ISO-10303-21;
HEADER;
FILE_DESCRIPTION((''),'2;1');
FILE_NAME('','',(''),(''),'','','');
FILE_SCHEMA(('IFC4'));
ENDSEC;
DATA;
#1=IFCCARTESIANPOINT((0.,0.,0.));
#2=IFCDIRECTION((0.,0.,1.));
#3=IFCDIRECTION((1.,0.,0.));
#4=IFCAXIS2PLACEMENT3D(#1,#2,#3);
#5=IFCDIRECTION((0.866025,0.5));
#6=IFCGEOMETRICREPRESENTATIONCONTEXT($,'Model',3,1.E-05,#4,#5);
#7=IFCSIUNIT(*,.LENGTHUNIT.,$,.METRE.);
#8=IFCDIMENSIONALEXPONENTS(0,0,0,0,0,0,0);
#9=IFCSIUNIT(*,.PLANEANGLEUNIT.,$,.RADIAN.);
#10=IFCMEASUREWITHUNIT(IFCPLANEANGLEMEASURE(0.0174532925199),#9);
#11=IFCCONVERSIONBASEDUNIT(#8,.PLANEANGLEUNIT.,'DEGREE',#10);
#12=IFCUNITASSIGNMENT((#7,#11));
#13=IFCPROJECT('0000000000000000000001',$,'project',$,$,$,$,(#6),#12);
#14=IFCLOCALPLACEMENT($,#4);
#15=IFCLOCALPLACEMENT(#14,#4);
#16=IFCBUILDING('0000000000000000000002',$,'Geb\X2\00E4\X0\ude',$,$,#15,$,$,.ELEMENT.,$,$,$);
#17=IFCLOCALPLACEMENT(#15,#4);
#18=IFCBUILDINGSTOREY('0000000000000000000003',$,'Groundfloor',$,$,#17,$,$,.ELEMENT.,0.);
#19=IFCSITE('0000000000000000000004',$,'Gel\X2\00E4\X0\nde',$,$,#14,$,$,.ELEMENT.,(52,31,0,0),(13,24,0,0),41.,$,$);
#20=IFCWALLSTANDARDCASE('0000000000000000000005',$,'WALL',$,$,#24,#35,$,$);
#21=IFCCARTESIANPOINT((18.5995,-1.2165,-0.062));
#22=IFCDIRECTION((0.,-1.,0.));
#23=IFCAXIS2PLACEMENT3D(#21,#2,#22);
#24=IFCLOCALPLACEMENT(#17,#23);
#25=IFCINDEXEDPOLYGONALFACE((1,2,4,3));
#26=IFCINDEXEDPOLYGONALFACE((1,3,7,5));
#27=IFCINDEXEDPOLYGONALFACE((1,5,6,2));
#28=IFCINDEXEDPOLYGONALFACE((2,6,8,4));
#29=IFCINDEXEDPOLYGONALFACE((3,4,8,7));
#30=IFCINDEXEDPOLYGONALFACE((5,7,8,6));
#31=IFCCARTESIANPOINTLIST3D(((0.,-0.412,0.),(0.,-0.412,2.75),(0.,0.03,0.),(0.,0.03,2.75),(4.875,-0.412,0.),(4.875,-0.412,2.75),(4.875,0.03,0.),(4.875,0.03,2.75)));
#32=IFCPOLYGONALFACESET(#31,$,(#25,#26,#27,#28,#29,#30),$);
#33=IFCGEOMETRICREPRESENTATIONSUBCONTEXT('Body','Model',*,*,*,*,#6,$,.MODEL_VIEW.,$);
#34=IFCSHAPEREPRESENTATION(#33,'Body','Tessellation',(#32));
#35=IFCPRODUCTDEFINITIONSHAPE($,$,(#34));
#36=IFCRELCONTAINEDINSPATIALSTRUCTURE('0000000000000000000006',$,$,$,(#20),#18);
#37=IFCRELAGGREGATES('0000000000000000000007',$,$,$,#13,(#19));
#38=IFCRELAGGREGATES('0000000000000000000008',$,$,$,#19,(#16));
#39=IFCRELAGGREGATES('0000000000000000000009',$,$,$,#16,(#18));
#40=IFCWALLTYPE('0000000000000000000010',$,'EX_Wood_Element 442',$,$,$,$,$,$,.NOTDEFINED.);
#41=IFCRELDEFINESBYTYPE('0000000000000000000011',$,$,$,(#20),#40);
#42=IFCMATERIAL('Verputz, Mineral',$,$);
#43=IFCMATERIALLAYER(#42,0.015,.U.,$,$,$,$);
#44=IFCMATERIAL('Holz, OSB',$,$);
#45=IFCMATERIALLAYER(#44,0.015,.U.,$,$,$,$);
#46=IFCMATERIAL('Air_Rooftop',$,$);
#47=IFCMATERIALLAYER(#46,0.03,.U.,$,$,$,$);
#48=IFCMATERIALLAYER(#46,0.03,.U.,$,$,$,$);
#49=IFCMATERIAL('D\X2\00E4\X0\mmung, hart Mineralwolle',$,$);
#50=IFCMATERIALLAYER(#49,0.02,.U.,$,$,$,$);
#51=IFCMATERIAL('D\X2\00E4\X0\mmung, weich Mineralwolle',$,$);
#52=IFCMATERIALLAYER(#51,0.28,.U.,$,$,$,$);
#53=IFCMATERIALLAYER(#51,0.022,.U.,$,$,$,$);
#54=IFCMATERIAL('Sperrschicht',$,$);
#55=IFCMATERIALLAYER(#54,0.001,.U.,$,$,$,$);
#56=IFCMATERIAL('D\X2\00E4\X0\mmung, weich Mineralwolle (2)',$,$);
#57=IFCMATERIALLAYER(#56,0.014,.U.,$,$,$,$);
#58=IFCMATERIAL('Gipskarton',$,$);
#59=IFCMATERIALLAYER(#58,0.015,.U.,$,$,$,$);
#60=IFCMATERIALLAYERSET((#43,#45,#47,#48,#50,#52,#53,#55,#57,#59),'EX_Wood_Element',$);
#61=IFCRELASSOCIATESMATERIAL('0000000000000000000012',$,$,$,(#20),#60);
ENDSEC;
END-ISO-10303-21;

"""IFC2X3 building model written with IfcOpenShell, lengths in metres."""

from ifc_helpers import new_model, entity, si_unit, converted_unit, direction, frame, origin_with_axes, place, context, subcontext, project, spatial, polyline, outline, extrude, material, layer, layer_set, layer_usage, type_object, element, save


model = new_model("IFC2X3")

# Units and contexts
model_context = context("Model", 3, precision=1e-05, world=origin_with_axes(), true_north=direction((0.866025, 0.5)))
body_context = subcontext(model_context, "Body", "Model", "MODEL_VIEW")
ifc_project = project(units=[si_unit("LENGTHUNIT", "METRE"), converted_unit("PLANEANGLEUNIT", "DEGREE", entity("IfcPlaneAngleMeasure", 0.0174532925199), si_unit("PLANEANGLEUNIT", "RADIAN"), dimensions=[0, 0, 0, 0, 0, 0, 0])], contexts=[model_context])

# Site, building, storey
site_placement = place(None, origin_with_axes())
site = spatial("IfcSite", under=ifc_project, at=site_placement, Name="Gelände", CompositionType="ELEMENT", RefLatitude=(52, 31, 0, 0), RefLongitude=(13, 24, 0, 0), RefElevation=41.0)
building_placement = place(site_placement, origin_with_axes())
building = spatial("IfcBuilding", under=site, at=building_placement, Name="Gebäude", CompositionType="ELEMENT")
storey_placement = place(building_placement, origin_with_axes())
storey = spatial("IfcBuildingStorey", under=building, at=storey_placement, Name="Groundfloor", CompositionType="ELEMENT", Elevation=0.0)

# Wall
ifc_material_1 = material(Name="Verputz, Mineral")
ifc_layer_1 = layer(ifc_material_1, 0.015, ventilated="UNKNOWN")
ifc_material_2 = material(Name="Holz, OSB")
ifc_layer_2 = layer(ifc_material_2, 0.015, ventilated="UNKNOWN")
ifc_material_3 = material(Name="Air_Rooftop")
ifc_layer_3 = layer(ifc_material_3, 0.03, ventilated="UNKNOWN")
ifc_layer_4 = layer(ifc_material_3, 0.03, ventilated="UNKNOWN")
ifc_material_4 = material(Name="Dämmung, hart Mineralwolle")
ifc_layer_5 = layer(ifc_material_4, 0.02, ventilated="UNKNOWN")
ifc_material_5 = material(Name="Dämmung, weich Mineralwolle")
ifc_layer_6 = layer(ifc_material_5, 0.28, ventilated="UNKNOWN")
ifc_layer_7 = layer(ifc_material_5, 0.022, ventilated="UNKNOWN")
ifc_material_6 = material(Name="Sperrschicht")
ifc_layer_8 = layer(ifc_material_6, 0.001, ventilated="UNKNOWN")
ifc_material_7 = material(Name="Dämmung, weich Mineralwolle (2)")
ifc_layer_9 = layer(ifc_material_7, 0.014, ventilated="UNKNOWN")
ifc_material_8 = material(Name="Gipskarton")
ifc_layer_10 = layer(ifc_material_8, 0.015, ventilated="UNKNOWN")
ifc_layer_set = layer_set([ifc_layer_1, ifc_layer_2, ifc_layer_3, ifc_layer_4, ifc_layer_5, ifc_layer_6, ifc_layer_7, ifc_layer_8, ifc_layer_9, ifc_layer_10], Name="EX_Wood_Element")
ifc_layer_usage = layer_usage(ifc_layer_set, "AXIS2", "NEGATIVE", 0.03)
wall_type = type_object("IfcWallType", Name="EX_Wood_Element 442", PredefinedType="NOTDEFINED")
wall_placement = place(storey_placement, frame((18.5995, -1.2165, -0.062), z_axis=(0.0, 0.0, 1.0), x_axis=(0.0, -1.0, 0.0)))
element("IfcWallStandardCase", 1, at=wall_placement, inside=storey, type_object=wall_type, material=ifc_layer_usage, Name="WALL", context=body_context, shape_type="SweptSolid", body=[
    extrude(outline(polyline([(0.0, -0.412), (4.875, -0.412), (4.875, 0.03), (0.0, 0.03), (0.0, -0.412)])), origin_with_axes(), (0.0, 0.0, 1.0), 2.75),
])

save(model, "model.ifc")
